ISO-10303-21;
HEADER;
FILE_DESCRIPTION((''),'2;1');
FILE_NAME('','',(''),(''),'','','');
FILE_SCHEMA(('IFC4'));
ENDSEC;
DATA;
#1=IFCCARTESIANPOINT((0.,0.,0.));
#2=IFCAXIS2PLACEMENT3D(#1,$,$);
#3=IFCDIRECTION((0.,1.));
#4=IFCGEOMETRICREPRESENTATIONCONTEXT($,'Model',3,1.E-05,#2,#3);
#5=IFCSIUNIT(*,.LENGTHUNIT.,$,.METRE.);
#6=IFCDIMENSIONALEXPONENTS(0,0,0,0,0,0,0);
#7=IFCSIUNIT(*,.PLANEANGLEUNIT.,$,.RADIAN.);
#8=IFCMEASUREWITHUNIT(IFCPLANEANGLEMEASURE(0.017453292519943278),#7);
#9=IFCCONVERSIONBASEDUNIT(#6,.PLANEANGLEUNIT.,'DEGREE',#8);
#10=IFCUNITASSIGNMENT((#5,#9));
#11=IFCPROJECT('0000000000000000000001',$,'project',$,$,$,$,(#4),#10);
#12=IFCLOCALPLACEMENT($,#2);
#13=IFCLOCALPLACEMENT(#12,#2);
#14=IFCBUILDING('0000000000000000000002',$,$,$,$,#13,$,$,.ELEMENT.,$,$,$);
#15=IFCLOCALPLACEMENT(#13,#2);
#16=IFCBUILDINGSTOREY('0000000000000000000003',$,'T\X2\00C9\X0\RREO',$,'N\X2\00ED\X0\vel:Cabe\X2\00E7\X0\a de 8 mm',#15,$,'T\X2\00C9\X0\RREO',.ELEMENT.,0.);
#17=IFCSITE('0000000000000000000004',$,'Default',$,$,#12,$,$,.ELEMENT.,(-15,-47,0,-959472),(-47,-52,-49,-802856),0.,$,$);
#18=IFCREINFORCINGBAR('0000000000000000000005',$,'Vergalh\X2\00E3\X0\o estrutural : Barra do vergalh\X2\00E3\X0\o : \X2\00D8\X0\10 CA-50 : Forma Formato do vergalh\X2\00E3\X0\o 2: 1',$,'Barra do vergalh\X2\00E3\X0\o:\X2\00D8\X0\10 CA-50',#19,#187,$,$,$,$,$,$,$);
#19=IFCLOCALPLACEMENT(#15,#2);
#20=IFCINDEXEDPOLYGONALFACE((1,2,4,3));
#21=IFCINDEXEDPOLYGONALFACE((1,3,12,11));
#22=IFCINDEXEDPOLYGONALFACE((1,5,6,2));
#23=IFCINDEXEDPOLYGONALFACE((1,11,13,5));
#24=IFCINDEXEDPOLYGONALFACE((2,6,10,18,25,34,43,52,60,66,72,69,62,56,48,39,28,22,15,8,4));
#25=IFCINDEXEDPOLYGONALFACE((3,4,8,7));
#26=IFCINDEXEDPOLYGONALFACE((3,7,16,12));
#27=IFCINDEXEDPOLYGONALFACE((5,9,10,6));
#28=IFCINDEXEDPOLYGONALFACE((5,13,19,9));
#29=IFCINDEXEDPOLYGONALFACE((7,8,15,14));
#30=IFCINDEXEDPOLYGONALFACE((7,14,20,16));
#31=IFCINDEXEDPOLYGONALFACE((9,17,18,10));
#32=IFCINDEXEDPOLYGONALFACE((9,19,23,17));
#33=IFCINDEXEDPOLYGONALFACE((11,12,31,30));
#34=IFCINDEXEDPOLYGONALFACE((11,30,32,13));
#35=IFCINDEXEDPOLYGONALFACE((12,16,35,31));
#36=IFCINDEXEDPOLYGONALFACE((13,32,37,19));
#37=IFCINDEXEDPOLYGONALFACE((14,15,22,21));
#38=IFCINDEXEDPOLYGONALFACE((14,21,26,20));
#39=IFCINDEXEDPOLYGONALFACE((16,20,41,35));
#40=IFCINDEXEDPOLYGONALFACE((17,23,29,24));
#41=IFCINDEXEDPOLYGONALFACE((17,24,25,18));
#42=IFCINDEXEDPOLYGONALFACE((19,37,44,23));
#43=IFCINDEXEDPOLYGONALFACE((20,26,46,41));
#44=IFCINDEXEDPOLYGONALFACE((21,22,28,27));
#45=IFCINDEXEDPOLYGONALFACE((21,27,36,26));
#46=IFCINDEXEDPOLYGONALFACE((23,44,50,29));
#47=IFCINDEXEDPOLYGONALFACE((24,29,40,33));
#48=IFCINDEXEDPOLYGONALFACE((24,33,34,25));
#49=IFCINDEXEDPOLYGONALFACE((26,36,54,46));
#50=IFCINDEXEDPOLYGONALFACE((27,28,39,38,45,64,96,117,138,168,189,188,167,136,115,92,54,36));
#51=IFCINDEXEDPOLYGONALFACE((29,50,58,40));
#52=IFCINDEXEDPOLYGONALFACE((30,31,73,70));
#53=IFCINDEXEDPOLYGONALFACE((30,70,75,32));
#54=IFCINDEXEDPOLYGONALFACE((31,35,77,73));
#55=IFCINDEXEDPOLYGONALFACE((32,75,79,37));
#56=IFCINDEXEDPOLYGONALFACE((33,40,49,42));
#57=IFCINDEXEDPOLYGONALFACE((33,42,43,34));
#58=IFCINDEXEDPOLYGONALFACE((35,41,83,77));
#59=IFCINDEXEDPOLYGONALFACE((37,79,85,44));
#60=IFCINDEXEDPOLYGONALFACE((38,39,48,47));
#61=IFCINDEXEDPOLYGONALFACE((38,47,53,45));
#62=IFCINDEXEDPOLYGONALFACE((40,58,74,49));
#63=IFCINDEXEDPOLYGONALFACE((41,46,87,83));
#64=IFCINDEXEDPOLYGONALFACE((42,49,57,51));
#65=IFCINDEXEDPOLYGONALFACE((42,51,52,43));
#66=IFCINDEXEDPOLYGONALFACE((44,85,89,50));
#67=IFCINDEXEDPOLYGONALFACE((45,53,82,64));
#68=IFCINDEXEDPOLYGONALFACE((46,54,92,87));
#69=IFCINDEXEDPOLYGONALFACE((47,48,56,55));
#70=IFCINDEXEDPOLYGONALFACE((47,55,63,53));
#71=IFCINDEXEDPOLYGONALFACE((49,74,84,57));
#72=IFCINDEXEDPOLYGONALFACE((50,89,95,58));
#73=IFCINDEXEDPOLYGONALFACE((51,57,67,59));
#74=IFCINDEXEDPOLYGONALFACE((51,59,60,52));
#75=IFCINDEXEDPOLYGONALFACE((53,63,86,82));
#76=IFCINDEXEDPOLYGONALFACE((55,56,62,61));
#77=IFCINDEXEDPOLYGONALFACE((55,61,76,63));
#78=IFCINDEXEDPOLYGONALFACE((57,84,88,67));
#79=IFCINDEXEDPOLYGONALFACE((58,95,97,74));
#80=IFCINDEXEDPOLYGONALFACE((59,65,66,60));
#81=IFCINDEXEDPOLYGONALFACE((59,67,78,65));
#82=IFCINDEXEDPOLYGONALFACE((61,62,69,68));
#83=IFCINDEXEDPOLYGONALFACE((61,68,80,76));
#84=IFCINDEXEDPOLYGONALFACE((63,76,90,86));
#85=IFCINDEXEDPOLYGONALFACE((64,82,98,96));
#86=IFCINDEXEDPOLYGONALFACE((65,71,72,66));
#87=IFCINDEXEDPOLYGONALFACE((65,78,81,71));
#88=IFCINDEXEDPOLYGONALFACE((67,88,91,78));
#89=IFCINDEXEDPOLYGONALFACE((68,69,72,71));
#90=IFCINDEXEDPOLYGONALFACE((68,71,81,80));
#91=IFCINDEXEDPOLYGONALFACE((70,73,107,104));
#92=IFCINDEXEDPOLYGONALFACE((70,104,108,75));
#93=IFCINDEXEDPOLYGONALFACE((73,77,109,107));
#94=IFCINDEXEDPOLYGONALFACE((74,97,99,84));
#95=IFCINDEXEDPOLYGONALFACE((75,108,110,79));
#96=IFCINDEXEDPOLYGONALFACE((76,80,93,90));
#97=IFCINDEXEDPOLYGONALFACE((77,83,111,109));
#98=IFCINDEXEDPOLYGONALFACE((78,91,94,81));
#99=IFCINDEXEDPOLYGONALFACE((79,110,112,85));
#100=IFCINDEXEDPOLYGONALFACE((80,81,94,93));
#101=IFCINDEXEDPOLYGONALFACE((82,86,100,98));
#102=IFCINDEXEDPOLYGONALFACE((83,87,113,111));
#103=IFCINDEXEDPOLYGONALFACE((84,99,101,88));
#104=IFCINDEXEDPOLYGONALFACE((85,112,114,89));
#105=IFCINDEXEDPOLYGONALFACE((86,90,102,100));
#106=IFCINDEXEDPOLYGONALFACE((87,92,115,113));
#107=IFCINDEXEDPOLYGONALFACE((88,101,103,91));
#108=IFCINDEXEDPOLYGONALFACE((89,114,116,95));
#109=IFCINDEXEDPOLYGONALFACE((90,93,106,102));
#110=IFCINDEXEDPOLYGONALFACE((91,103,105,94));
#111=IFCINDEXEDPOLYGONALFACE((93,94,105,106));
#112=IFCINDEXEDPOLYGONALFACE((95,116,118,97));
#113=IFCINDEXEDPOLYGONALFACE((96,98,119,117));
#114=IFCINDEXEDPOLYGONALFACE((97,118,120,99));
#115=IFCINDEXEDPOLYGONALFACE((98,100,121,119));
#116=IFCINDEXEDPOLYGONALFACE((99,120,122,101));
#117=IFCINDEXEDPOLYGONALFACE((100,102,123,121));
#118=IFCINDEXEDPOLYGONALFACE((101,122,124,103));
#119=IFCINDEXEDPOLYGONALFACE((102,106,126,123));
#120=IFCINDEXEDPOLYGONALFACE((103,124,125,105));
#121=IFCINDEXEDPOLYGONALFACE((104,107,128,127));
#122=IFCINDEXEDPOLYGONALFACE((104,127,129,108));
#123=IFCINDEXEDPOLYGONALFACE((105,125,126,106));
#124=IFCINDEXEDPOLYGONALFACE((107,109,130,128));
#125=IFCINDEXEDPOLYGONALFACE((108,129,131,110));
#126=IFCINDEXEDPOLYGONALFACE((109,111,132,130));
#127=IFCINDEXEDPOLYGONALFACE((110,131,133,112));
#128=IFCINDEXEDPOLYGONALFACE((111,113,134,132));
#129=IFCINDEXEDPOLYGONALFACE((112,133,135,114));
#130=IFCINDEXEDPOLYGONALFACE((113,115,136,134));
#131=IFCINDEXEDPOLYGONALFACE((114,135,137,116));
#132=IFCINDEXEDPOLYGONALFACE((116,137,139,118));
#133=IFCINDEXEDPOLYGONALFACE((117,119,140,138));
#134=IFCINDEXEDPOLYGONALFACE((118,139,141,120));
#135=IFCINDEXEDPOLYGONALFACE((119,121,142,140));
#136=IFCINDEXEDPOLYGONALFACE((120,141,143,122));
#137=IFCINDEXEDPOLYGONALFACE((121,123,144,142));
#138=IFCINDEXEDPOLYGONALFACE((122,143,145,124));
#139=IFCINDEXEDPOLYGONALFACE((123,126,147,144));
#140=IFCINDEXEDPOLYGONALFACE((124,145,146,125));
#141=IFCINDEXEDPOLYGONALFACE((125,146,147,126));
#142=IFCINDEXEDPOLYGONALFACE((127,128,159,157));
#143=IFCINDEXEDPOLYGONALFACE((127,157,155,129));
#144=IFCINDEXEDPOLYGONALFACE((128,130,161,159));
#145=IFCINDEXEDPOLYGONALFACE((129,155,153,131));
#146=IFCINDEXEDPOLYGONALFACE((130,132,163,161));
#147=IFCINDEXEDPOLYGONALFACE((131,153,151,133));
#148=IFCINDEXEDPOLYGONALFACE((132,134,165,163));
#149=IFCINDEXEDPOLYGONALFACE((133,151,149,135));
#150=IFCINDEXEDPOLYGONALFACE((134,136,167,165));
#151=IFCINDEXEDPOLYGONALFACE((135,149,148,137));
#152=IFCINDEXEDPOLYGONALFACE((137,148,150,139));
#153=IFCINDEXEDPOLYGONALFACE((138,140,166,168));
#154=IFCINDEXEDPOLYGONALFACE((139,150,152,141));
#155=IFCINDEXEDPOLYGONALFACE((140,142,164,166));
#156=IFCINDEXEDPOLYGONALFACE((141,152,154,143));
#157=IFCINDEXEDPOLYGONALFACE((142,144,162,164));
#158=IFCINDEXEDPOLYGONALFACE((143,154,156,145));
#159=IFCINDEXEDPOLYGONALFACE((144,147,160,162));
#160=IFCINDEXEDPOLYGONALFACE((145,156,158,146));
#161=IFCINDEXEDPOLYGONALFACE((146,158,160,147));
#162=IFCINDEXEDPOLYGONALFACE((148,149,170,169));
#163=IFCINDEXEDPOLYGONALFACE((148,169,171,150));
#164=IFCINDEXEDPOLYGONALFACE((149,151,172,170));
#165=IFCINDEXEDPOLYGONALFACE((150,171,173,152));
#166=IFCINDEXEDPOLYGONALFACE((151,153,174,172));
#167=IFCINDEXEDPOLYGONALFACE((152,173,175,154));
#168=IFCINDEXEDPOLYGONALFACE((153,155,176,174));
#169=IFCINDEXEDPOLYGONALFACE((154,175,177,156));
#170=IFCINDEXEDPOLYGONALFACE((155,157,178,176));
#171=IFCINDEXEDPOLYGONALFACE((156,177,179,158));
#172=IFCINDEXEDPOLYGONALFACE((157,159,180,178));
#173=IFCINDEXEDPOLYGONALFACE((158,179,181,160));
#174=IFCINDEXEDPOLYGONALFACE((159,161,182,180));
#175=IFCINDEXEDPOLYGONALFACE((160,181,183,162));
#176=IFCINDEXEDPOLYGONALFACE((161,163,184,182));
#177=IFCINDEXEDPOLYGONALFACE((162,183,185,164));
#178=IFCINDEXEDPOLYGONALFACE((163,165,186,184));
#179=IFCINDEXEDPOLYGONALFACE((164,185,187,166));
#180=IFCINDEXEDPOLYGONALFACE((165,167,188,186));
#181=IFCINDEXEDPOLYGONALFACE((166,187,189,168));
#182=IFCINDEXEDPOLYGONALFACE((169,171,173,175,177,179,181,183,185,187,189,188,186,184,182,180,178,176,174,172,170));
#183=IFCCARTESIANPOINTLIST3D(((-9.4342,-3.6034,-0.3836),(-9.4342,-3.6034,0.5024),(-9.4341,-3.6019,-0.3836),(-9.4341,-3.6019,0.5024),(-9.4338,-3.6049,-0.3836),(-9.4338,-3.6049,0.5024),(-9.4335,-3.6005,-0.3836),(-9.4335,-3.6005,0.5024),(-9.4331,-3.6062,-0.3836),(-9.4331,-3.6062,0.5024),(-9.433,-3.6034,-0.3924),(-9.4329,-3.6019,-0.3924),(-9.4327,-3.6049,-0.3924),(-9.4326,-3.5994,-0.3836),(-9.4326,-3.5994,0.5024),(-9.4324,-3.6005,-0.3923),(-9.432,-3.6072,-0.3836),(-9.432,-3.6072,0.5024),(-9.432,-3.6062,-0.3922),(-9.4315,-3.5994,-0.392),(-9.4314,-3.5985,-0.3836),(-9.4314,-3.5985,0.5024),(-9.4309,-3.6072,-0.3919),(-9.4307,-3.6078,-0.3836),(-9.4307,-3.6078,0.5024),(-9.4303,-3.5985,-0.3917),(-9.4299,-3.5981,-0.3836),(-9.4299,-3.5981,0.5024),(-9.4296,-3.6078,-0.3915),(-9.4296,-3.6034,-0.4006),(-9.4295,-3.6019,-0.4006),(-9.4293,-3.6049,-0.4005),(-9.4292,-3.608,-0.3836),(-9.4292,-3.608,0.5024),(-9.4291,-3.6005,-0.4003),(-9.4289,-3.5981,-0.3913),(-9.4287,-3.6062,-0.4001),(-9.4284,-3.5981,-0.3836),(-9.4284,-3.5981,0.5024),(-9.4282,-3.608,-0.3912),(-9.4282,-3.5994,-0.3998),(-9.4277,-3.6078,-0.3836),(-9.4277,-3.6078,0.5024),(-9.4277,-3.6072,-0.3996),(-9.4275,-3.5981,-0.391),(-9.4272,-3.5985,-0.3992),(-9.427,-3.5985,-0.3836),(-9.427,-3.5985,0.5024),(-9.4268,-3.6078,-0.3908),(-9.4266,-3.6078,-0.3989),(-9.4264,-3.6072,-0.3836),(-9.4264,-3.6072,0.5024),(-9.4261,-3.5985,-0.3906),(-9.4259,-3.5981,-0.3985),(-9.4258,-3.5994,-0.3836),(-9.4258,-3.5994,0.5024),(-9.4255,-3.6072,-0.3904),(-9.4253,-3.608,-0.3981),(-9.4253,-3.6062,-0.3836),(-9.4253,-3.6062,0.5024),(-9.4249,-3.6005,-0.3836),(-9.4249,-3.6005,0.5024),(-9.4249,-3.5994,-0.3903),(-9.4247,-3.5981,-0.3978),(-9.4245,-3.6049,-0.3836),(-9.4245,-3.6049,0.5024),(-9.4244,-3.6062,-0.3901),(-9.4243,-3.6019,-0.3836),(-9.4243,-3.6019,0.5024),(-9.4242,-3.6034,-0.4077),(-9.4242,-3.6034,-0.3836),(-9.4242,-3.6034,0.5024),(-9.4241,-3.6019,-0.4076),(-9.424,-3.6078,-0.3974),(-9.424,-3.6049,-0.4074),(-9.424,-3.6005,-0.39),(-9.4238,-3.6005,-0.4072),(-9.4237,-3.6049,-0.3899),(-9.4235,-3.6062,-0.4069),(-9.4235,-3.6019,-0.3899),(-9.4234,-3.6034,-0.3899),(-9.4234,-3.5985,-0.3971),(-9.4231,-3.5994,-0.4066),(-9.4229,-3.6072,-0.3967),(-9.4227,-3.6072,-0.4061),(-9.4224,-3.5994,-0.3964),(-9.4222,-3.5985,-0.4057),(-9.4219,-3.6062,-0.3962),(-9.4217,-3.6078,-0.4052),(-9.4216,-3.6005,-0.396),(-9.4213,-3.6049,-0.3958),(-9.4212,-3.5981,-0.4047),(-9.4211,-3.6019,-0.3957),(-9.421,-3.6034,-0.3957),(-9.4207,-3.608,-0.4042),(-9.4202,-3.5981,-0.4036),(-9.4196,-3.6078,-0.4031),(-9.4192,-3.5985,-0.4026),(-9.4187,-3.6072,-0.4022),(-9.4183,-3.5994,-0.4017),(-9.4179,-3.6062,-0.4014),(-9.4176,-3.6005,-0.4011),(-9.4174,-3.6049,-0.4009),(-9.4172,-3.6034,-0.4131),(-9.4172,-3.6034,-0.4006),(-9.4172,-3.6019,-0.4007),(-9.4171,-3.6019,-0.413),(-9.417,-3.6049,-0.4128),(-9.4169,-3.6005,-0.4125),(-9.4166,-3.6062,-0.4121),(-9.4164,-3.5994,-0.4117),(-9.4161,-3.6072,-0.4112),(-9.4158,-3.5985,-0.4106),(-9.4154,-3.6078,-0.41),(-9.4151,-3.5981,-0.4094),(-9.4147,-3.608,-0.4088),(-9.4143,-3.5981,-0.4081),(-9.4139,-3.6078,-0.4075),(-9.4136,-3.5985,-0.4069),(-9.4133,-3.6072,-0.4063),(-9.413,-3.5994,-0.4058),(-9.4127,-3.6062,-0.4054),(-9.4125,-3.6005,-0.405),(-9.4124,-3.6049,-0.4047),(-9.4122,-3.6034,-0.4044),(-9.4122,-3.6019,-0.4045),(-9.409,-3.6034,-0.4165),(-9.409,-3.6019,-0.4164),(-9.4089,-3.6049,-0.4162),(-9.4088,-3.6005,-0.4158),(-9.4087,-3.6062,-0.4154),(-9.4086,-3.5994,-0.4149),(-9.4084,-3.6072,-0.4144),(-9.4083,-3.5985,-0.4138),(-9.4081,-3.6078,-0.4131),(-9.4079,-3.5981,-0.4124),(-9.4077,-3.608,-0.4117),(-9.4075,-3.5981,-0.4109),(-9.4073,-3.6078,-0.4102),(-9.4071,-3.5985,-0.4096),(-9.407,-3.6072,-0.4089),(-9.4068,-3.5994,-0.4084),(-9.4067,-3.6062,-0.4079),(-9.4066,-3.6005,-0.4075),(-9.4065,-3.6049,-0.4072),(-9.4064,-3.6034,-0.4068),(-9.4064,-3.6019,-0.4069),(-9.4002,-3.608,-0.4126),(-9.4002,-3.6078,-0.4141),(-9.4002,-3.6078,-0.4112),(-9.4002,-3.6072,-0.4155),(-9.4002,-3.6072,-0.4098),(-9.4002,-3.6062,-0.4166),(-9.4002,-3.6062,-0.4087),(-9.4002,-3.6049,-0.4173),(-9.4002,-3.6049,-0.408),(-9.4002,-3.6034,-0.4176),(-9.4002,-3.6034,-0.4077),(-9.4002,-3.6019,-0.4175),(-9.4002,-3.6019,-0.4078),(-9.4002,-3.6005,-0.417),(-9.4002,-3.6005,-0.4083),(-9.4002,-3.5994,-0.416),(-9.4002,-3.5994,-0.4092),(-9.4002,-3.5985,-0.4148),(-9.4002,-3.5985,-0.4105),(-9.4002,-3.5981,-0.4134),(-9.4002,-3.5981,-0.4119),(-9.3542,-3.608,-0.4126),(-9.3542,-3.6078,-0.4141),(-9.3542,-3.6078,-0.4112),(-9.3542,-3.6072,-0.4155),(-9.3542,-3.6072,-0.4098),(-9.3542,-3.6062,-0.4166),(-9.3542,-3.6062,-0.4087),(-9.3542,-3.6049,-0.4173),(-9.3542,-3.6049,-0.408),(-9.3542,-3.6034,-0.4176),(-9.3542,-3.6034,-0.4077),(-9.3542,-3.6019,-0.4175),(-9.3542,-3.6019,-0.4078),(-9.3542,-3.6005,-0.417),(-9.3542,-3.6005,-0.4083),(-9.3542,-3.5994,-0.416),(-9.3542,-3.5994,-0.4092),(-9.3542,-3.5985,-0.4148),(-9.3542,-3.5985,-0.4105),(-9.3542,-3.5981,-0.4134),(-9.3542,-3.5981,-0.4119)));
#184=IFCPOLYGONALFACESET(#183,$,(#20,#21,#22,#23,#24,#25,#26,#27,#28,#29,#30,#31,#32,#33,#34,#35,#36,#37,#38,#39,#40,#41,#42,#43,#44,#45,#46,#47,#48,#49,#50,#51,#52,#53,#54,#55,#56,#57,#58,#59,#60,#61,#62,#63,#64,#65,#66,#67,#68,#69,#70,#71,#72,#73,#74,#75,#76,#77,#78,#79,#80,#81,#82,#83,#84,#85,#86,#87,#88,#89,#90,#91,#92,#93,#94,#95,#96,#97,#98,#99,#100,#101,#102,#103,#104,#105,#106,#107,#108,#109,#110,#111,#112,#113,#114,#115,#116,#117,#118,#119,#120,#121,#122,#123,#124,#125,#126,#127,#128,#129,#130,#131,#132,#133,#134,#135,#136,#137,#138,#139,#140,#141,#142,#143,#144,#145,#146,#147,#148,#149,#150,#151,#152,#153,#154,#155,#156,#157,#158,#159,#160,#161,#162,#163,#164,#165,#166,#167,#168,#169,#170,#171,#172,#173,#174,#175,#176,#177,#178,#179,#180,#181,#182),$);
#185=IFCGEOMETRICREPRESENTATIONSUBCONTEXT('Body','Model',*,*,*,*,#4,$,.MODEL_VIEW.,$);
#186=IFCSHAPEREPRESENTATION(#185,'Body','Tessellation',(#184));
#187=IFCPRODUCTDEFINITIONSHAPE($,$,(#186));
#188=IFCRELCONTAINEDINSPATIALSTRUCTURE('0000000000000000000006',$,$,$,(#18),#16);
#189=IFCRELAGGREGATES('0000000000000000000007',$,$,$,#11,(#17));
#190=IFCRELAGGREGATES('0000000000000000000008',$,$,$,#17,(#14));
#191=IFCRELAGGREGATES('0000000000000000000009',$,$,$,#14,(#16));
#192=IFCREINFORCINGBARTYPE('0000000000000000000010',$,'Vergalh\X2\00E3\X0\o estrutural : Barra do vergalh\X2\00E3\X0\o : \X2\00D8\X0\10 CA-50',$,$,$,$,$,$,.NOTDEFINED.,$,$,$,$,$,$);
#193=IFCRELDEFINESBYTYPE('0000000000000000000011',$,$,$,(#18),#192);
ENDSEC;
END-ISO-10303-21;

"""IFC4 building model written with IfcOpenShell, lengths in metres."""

from ifc_helpers import new_model, entity, si_unit, converted_unit, direction, origin, place, context, subcontext, project, spatial, type_object, element, save


model = new_model("IFC4")

# Units and contexts
model_context = context("Model", 3, precision=1e-05, world=origin(), true_north=direction((0.0, 1.0)))
body_context = subcontext(model_context, "Body", "Model", "MODEL_VIEW")
ifc_project = project(units=[si_unit("LENGTHUNIT", "METRE"), converted_unit("PLANEANGLEUNIT", "DEGREE", entity("IfcPlaneAngleMeasure", 0.017453292519943278), si_unit("PLANEANGLEUNIT", "RADIAN"), dimensions=[0, 0, 0, 0, 0, 0, 0])], contexts=[model_context])

# Site, building, storey
site_placement = place(None, origin())
site = spatial("IfcSite", under=ifc_project, at=site_placement, Name="Default", CompositionType="ELEMENT", RefLatitude=(-15, -47, 0, -959472), RefLongitude=(-47, -52, -49, -802856), RefElevation=0.0)
building_placement = place(site_placement, origin())
building = spatial("IfcBuilding", under=site, at=building_placement, CompositionType="ELEMENT")
storey_placement = place(building_placement, origin())
storey = spatial("IfcBuildingStorey", under=building, at=storey_placement, Name="TÉRREO", ObjectType="Nível:Cabeça de 8 mm", LongName="TÉRREO", CompositionType="ELEMENT", Elevation=0.0)

# Reinforcing bar
reinforcing_bar_type_1 = type_object("IfcReinforcingBarType", Name="Vergalhão estrutural : Barra do vergalhão : Ø10 CA-50", PredefinedType="NOTDEFINED")
reinforcing_bar_1_placement = place(storey_placement, origin())
element("IfcReinforcingBar", 1, at=reinforcing_bar_1_placement, inside=storey, type_object=reinforcing_bar_type_1, Name="Vergalhão estrutural : Barra do vergalhão : Ø10 CA-50 : Forma Formato do vergalhão 2: 1", ObjectType="Barra do vergalhão:Ø10 CA-50", context=body_context, shape_type="AdvancedSweptSolid", body=[
    entity("IfcSweptDiskSolid", entity("IfcIndexedPolyCurve", entity("IfcCartesianPointList3D", [[-9.3542, -3.603, -0.4126], [-9.4002, -3.603, -0.4126], [-9.4207, -3.603, -0.4042], [-9.4292, -3.603, -0.3836], [-9.4292, -3.603, 0.5024]]), [entity("IfcLineIndex", [1, 2]), entity("IfcArcIndex", [2, 3, 4]), entity("IfcLineIndex", [4, 5])], False), 0.005, None, 0.0, 92.0),
])

save(model, "model.ifc")
